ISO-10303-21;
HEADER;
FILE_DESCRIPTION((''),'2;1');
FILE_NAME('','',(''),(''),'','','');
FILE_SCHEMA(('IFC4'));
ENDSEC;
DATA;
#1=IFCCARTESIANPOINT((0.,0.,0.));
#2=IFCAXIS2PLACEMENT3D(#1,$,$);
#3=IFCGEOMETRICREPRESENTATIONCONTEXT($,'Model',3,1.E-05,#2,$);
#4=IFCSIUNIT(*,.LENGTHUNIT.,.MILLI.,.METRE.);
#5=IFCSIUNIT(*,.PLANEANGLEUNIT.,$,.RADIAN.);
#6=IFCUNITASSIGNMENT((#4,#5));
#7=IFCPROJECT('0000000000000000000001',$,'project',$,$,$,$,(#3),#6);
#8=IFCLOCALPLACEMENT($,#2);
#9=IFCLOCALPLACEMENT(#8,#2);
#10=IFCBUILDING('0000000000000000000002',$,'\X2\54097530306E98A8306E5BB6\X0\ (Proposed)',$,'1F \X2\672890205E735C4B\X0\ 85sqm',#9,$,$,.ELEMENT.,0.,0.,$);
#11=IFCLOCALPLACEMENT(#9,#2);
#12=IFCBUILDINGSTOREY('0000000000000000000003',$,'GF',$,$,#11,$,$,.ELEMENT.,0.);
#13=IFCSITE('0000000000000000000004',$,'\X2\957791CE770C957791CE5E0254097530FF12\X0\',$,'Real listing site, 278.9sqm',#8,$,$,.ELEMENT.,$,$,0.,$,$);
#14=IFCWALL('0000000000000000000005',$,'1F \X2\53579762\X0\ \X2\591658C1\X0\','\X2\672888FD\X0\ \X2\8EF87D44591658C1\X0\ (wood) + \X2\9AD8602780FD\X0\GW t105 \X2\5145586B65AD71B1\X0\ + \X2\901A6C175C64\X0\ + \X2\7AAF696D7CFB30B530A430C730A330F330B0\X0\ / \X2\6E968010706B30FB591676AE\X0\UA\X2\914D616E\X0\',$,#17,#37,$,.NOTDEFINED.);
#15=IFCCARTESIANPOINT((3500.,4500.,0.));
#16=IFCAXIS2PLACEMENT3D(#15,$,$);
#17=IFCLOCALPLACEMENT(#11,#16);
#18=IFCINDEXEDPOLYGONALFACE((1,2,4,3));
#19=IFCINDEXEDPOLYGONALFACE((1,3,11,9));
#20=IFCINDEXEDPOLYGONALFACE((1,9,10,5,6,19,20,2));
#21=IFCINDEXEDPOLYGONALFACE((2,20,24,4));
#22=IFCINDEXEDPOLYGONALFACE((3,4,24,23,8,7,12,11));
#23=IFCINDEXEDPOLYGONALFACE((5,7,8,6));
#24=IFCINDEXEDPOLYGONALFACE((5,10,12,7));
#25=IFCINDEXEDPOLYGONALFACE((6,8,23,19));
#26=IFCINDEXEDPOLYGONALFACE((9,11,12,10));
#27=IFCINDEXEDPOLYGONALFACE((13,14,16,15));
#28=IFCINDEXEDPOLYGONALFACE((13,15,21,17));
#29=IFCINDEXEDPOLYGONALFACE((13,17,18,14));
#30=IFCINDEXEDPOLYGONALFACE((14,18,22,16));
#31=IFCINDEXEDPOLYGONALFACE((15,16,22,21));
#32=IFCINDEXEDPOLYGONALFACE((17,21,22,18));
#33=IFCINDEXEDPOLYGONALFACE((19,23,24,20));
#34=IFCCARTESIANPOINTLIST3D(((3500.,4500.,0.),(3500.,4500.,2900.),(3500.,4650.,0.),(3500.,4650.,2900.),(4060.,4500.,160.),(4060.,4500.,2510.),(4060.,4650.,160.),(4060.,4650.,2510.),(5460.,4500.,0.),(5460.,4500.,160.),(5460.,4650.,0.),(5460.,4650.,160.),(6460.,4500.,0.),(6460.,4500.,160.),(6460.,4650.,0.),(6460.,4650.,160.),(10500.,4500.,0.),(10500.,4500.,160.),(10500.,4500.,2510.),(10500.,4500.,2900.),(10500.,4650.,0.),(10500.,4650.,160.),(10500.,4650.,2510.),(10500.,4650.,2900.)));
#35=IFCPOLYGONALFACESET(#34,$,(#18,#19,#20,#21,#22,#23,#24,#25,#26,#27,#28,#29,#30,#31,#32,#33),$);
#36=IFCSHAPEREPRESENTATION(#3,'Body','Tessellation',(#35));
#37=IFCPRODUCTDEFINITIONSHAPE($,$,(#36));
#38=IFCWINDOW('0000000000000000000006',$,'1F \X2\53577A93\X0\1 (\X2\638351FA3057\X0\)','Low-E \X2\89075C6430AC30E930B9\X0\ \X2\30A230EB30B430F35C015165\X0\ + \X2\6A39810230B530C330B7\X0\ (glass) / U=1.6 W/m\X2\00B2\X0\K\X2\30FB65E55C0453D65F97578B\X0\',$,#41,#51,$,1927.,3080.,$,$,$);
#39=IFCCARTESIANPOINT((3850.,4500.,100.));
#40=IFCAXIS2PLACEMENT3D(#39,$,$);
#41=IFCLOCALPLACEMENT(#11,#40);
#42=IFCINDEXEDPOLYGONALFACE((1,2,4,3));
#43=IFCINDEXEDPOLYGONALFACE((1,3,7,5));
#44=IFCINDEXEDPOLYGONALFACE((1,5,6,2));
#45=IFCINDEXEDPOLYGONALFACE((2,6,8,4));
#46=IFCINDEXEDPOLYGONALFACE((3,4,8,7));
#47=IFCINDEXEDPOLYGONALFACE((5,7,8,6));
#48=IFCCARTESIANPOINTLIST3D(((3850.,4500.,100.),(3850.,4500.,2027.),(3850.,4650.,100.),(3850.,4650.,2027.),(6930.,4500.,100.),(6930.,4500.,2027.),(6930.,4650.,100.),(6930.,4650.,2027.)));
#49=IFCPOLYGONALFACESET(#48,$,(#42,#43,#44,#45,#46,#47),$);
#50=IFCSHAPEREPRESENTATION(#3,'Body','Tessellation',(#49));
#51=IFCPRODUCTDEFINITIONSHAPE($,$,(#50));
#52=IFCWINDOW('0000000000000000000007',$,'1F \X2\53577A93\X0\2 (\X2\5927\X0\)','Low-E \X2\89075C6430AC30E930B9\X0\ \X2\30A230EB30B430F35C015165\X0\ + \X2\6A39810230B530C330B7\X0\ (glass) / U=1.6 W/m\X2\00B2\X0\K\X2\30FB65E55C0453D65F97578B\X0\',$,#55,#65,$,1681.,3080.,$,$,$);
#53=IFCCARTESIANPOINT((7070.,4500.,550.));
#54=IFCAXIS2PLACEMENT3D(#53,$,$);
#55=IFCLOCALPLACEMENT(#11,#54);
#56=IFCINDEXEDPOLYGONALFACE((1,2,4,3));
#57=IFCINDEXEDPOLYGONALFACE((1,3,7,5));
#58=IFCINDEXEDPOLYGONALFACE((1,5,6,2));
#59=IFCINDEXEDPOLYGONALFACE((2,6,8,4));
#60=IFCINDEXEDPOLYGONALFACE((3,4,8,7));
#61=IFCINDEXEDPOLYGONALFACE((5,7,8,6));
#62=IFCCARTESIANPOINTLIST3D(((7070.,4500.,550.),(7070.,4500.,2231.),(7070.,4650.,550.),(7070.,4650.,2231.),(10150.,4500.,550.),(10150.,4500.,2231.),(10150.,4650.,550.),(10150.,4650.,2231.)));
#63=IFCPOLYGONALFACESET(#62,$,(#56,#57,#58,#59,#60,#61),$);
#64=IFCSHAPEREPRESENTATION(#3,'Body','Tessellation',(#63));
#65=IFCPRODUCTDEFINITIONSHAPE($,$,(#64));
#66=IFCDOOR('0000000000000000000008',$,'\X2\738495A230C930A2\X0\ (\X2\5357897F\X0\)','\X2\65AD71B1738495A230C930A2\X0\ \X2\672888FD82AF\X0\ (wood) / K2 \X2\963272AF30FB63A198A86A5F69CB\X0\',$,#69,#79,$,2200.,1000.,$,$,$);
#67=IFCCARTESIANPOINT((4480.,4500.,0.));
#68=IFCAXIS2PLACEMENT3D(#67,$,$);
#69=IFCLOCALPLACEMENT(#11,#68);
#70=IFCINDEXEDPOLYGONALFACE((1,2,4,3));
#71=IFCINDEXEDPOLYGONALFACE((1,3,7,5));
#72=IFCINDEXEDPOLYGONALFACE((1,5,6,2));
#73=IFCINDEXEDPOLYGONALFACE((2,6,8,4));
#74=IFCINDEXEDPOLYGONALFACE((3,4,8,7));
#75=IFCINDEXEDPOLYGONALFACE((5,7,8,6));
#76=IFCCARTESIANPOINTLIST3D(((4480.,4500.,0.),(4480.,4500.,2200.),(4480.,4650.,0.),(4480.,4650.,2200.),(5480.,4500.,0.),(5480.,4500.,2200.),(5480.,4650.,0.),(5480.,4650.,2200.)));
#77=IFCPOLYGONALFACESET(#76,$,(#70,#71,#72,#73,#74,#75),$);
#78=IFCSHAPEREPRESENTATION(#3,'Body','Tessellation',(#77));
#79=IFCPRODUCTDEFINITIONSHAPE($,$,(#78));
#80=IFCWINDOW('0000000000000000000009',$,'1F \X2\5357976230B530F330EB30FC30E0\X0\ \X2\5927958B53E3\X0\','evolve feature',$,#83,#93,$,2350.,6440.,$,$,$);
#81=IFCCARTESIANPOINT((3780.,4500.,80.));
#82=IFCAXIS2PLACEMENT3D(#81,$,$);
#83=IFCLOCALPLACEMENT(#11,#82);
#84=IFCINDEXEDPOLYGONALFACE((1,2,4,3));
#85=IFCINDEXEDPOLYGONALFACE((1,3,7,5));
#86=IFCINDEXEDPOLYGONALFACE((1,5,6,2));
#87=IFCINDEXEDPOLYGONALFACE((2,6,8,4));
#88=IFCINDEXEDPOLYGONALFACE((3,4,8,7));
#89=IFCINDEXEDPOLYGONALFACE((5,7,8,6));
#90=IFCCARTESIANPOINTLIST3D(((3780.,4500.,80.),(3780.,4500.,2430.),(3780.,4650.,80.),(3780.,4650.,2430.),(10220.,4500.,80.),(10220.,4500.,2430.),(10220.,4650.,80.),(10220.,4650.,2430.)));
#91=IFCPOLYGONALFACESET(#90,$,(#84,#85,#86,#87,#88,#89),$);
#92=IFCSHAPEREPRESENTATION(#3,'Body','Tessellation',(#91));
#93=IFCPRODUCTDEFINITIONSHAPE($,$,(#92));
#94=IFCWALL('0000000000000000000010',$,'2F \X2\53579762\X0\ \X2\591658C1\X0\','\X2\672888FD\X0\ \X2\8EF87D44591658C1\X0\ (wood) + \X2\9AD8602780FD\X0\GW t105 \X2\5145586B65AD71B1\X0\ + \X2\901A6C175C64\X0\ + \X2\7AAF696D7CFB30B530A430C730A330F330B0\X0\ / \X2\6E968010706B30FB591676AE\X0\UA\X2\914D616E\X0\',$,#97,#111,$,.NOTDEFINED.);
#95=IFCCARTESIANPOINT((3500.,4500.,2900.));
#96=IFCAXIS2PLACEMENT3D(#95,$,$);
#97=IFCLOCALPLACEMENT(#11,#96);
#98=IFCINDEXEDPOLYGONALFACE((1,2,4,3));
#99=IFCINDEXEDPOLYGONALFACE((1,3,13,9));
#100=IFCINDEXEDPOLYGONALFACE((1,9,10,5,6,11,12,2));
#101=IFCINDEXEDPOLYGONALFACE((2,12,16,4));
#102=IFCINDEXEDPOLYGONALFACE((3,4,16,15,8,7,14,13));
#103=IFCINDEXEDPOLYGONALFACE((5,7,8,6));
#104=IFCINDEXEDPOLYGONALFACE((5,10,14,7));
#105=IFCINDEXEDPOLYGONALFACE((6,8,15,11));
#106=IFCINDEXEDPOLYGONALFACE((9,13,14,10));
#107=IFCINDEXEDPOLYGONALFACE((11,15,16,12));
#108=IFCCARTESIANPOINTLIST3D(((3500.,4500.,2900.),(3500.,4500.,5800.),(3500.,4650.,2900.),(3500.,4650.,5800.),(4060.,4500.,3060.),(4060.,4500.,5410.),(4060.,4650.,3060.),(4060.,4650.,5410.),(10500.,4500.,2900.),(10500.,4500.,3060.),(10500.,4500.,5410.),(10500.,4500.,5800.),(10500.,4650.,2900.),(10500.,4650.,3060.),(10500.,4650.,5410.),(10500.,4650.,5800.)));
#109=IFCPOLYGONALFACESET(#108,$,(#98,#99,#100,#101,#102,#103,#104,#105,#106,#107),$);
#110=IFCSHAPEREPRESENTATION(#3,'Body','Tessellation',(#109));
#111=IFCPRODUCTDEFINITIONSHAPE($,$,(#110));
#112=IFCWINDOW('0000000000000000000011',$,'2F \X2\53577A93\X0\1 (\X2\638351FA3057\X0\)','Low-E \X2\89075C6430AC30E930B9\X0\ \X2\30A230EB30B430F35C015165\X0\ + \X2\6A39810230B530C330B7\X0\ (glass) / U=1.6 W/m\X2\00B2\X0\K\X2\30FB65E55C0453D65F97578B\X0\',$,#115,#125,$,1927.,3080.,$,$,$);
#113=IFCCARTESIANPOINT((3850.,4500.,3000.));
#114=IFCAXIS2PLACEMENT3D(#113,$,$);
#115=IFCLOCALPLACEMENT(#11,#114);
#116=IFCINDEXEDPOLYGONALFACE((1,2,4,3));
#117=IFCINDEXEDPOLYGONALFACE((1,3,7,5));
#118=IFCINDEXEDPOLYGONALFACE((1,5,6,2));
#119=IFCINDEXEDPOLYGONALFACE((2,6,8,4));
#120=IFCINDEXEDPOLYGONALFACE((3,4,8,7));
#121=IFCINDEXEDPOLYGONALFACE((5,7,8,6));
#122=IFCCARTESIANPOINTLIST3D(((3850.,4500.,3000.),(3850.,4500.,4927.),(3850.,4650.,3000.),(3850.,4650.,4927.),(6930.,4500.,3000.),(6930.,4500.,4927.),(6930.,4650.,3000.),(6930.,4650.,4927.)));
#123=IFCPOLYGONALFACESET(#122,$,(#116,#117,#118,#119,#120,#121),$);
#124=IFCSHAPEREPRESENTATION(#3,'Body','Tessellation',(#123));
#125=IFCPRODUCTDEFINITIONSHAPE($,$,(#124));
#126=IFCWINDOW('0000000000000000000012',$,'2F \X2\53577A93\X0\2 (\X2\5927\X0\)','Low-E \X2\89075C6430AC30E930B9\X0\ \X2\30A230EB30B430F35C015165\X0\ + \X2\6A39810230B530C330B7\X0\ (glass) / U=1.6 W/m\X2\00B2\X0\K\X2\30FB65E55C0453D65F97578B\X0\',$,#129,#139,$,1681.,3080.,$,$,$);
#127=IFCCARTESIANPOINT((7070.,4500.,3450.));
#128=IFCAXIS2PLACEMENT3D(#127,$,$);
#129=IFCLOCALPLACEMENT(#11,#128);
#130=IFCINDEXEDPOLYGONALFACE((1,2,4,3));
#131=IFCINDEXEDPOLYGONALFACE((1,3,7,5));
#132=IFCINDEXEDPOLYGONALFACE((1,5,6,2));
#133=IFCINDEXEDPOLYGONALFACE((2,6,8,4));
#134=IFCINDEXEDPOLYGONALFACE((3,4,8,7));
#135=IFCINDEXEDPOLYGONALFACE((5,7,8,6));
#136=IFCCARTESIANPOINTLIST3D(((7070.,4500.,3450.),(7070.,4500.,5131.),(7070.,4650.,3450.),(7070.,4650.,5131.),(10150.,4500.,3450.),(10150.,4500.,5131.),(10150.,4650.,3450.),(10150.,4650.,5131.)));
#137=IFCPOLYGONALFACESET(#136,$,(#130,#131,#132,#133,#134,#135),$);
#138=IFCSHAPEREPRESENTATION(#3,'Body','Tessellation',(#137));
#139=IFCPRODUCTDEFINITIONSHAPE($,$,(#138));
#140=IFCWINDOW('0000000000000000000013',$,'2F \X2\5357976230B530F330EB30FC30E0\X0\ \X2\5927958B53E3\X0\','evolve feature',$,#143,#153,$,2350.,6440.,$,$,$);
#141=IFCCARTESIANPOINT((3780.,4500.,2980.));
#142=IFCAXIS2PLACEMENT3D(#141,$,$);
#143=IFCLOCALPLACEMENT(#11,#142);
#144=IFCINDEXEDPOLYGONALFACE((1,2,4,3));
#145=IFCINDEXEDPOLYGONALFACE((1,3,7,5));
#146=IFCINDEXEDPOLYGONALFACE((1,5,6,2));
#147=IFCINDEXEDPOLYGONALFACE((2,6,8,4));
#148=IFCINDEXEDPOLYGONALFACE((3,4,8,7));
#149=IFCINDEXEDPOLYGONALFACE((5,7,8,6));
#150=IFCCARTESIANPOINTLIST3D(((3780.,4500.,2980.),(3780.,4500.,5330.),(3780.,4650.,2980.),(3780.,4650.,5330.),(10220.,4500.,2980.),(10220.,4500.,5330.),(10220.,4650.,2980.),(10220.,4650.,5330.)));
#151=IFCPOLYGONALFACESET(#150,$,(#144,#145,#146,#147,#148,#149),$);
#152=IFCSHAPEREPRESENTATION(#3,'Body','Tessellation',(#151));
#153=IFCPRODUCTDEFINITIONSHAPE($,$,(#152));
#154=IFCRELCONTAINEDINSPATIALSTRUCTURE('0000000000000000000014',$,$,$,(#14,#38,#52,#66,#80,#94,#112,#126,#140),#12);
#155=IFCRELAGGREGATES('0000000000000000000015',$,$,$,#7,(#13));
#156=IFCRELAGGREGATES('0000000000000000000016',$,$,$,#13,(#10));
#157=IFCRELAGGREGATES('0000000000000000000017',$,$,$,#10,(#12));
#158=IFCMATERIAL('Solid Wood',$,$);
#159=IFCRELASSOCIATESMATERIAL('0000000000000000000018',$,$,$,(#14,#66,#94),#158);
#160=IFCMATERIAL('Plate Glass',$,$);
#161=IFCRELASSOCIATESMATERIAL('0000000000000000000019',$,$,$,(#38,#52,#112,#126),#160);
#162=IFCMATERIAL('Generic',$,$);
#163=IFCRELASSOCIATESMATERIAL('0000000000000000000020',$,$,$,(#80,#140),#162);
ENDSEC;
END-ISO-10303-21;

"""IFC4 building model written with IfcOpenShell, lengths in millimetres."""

from ifc_helpers import new_model, si_unit, frame, frame_2d, origin, place, context, project, spatial, rectangle, extrude, material, element, fill, save


model = new_model("IFC4")

# Units and contexts
model_context = context("Model", 3, precision=1e-05, world=origin())
ifc_project = project(units=[si_unit("LENGTHUNIT", "METRE", prefix="MILLI"), si_unit("PLANEANGLEUNIT", "RADIAN")], contexts=[model_context])

# Site, building, storey
site_placement = place(None, origin())
site = spatial("IfcSite", under=ifc_project, at=site_placement, Name="長野県長野市吉田２", ObjectType="Real listing site, 278.9sqm", CompositionType="ELEMENT", RefElevation=0.0)
building_placement = place(site_placement, origin())
building = spatial("IfcBuilding", under=site, at=building_placement, Name="吉田の風の家 (Proposed)", ObjectType="1F 木造平屋 85sqm", CompositionType="ELEMENT", ElevationOfRefHeight=0.0, ElevationOfTerrain=0.0)
storey_placement = place(building_placement, origin())
storey = spatial("IfcBuildingStorey", under=building, at=storey_placement, Name="GF", CompositionType="ELEMENT", Elevation=0.0)

# Shared definitions
ifc_material_1 = material(Name="Solid Wood")
ifc_material_2 = material(Name="Generic")

# Wall, openings, windows, door
wall_1_placement = place(storey_placement, frame((3500.0, 4500.0, 0.0)))
wall_1 = element("IfcWall", 1, at=wall_1_placement, inside=storey, material=ifc_material_1, Name="1F 南面 外壁", Description="木製 軸組外壁 (wood) + 高性能GW t105 充填断熱 + 通気層 + 窯業系サイディング / 準耐火・外皮UA配慮", PredefinedType="NOTDEFINED", context=model_context, shape_type="SweptSolid", body=[
    extrude(rectangle(XDim=7000.0, YDim=150.0, at=frame_2d((3500.0, 75.0))), frame((3500.0, 4500.0, 0.0)), (0.0, 0.0, 1.0), 2900.0),
])
opening_1_placement = place(storey_placement, frame((3850.0, 4500.0, 100.0)))
opening_1 = element("IfcOpeningElement", 2, at=opening_1_placement, cuts=wall_1, PredefinedType="NOTDEFINED", context=model_context, shape_type="SweptSolid", body=[
    extrude(rectangle(XDim=3080.0, YDim=150.0, at=frame_2d((1540.0, 75.0))), frame((3850.0, 4500.0, 100.0)), (0.0, 0.0, 1.0), 1927.0),
])
opening_2_placement = place(storey_placement, frame((7070.0, 4500.0, 550.0)))
opening_2 = element("IfcOpeningElement", 3, at=opening_2_placement, cuts=wall_1, PredefinedType="NOTDEFINED", context=model_context, shape_type="SweptSolid", body=[
    extrude(rectangle(XDim=3080.0, YDim=150.0, at=frame_2d((1540.0, 75.0))), frame((7070.0, 4500.0, 550.0)), (0.0, 0.0, 1.0), 1681.0),
])
opening_3_placement = place(storey_placement, frame((4480.0, 4500.0, 0.0)))
opening_3 = element("IfcOpeningElement", 4, at=opening_3_placement, cuts=wall_1, PredefinedType="NOTDEFINED", context=model_context, shape_type="SweptSolid", body=[
    extrude(rectangle(XDim=1000.0, YDim=150.0, at=frame_2d((500.0, 75.0))), frame((4480.0, 4500.0, 0.0)), (0.0, 0.0, 1.0), 2200.0),
])
opening_4_placement = place(storey_placement, frame((3780.0, 4500.0, 80.0)))
opening_4 = element("IfcOpeningElement", 5, at=opening_4_placement, cuts=wall_1, PredefinedType="NOTDEFINED", context=model_context, shape_type="SweptSolid", body=[
    extrude(rectangle(XDim=6440.0, YDim=150.0, at=frame_2d((3220.0, 75.0))), frame((3780.0, 4500.0, 80.0)), (0.0, 0.0, 1.0), 2350.0),
])
ifc_material_3 = material(Name="Plate Glass")
window_1_placement = place(storey_placement, frame((3850.0, 4500.0, 100.0)))
window_1 = element("IfcWindow", 6, at=window_1_placement, inside=storey, material=ifc_material_3, Name="1F 南窓1 (掃出し)", Description="Low-E 複層ガラス アルゴン封入 + 樹脂サッシ (glass) / U=1.6 W/m²K・日射取得型", OverallHeight=1927.0, OverallWidth=3080.0, context=model_context, shape_type="SweptSolid", body=[
    extrude(rectangle(XDim=3080.0, YDim=150.0, at=frame_2d((1540.0, 75.0))), frame((3850.0, 4500.0, 100.0)), (0.0, 0.0, 1.0), 1927.0),
])
fill(opening_1, window_1)
window_2_placement = place(storey_placement, frame((7070.0, 4500.0, 550.0)))
window_2 = element("IfcWindow", 7, at=window_2_placement, inside=storey, material=ifc_material_3, Name="1F 南窓2 (大)", Description="Low-E 複層ガラス アルゴン封入 + 樹脂サッシ (glass) / U=1.6 W/m²K・日射取得型", OverallHeight=1681.0, OverallWidth=3080.0, context=model_context, shape_type="SweptSolid", body=[
    extrude(rectangle(XDim=3080.0, YDim=150.0, at=frame_2d((1540.0, 75.0))), frame((7070.0, 4500.0, 550.0)), (0.0, 0.0, 1.0), 1681.0),
])
fill(opening_2, window_2)
door_placement = place(storey_placement, frame((4480.0, 4500.0, 0.0)))
door = element("IfcDoor", 8, at=door_placement, inside=storey, material=ifc_material_1, Name="玄関ドア (南西)", Description="断熱玄関ドア 木製芯 (wood) / K2 防犯・採風機構", OverallHeight=2200.0, OverallWidth=1000.0, context=model_context, shape_type="SweptSolid", body=[
    extrude(rectangle(XDim=1000.0, YDim=150.0, at=frame_2d((500.0, 75.0))), frame((4480.0, 4500.0, 0.0)), (0.0, 0.0, 1.0), 2200.0),
])
fill(opening_3, door)
window_3_placement = place(storey_placement, frame((3780.0, 4500.0, 80.0)))
window_3 = element("IfcWindow", 9, at=window_3_placement, inside=storey, material=ifc_material_2, Name="1F 南面サンルーム 大開口", Description="evolve feature", OverallHeight=2350.0, OverallWidth=6440.0, context=model_context, shape_type="SweptSolid", body=[
    extrude(rectangle(XDim=6440.0, YDim=150.0, at=frame_2d((3220.0, 75.0))), frame((3780.0, 4500.0, 80.0)), (0.0, 0.0, 1.0), 2350.0),
])
fill(opening_4, window_3)

# Wall, openings, windows
wall_2_placement = place(storey_placement, frame((3500.0, 4500.0, 2900.0)))
wall_2 = element("IfcWall", 10, at=wall_2_placement, inside=storey, material=ifc_material_1, Name="2F 南面 外壁", Description="木製 軸組外壁 (wood) + 高性能GW t105 充填断熱 + 通気層 + 窯業系サイディング / 準耐火・外皮UA配慮", PredefinedType="NOTDEFINED", context=model_context, shape_type="SweptSolid", body=[
    extrude(rectangle(XDim=7000.0, YDim=150.0, at=frame_2d((3500.0, 75.0))), frame((3500.0, 4500.0, 2900.0)), (0.0, 0.0, 1.0), 2900.0),
])
opening_5_placement = place(storey_placement, frame((3850.0, 4500.0, 3000.0)))
opening_5 = element("IfcOpeningElement", 11, at=opening_5_placement, cuts=wall_2, PredefinedType="NOTDEFINED", context=model_context, shape_type="SweptSolid", body=[
    extrude(rectangle(XDim=3080.0, YDim=150.0, at=frame_2d((1540.0, 75.0))), frame((3850.0, 4500.0, 3000.0)), (0.0, 0.0, 1.0), 1927.0),
])
opening_6_placement = place(storey_placement, frame((7070.0, 4500.0, 3450.0)))
opening_6 = element("IfcOpeningElement", 12, at=opening_6_placement, cuts=wall_2, PredefinedType="NOTDEFINED", context=model_context, shape_type="SweptSolid", body=[
    extrude(rectangle(XDim=3080.0, YDim=150.0, at=frame_2d((1540.0, 75.0))), frame((7070.0, 4500.0, 3450.0)), (0.0, 0.0, 1.0), 1681.0),
])
opening_7_placement = place(storey_placement, frame((3780.0, 4500.0, 2980.0)))
opening_7 = element("IfcOpeningElement", 13, at=opening_7_placement, cuts=wall_2, PredefinedType="NOTDEFINED", context=model_context, shape_type="SweptSolid", body=[
    extrude(rectangle(XDim=6440.0, YDim=150.0, at=frame_2d((3220.0, 75.0))), frame((3780.0, 4500.0, 2980.0)), (0.0, 0.0, 1.0), 2350.0),
])
window_4_placement = place(storey_placement, frame((3850.0, 4500.0, 3000.0)))
window_4 = element("IfcWindow", 14, at=window_4_placement, inside=storey, material=ifc_material_3, Name="2F 南窓1 (掃出し)", Description="Low-E 複層ガラス アルゴン封入 + 樹脂サッシ (glass) / U=1.6 W/m²K・日射取得型", OverallHeight=1927.0, OverallWidth=3080.0, context=model_context, shape_type="SweptSolid", body=[
    extrude(rectangle(XDim=3080.0, YDim=150.0, at=frame_2d((1540.0, 75.0))), frame((3850.0, 4500.0, 3000.0)), (0.0, 0.0, 1.0), 1927.0),
])
fill(opening_5, window_4)
window_5_placement = place(storey_placement, frame((7070.0, 4500.0, 3450.0)))
window_5 = element("IfcWindow", 15, at=window_5_placement, inside=storey, material=ifc_material_3, Name="2F 南窓2 (大)", Description="Low-E 複層ガラス アルゴン封入 + 樹脂サッシ (glass) / U=1.6 W/m²K・日射取得型", OverallHeight=1681.0, OverallWidth=3080.0, context=model_context, shape_type="SweptSolid", body=[
    extrude(rectangle(XDim=3080.0, YDim=150.0, at=frame_2d((1540.0, 75.0))), frame((7070.0, 4500.0, 3450.0)), (0.0, 0.0, 1.0), 1681.0),
])
fill(opening_6, window_5)
window_6_placement = place(storey_placement, frame((3780.0, 4500.0, 2980.0)))
window_6 = element("IfcWindow", 16, at=window_6_placement, inside=storey, material=ifc_material_2, Name="2F 南面サンルーム 大開口", Description="evolve feature", OverallHeight=2350.0, OverallWidth=6440.0, context=model_context, shape_type="SweptSolid", body=[
    extrude(rectangle(XDim=6440.0, YDim=150.0, at=frame_2d((3220.0, 75.0))), frame((3780.0, 4500.0, 2980.0)), (0.0, 0.0, 1.0), 2350.0),
])
fill(opening_7, window_6)

save(model, "model.ifc")
